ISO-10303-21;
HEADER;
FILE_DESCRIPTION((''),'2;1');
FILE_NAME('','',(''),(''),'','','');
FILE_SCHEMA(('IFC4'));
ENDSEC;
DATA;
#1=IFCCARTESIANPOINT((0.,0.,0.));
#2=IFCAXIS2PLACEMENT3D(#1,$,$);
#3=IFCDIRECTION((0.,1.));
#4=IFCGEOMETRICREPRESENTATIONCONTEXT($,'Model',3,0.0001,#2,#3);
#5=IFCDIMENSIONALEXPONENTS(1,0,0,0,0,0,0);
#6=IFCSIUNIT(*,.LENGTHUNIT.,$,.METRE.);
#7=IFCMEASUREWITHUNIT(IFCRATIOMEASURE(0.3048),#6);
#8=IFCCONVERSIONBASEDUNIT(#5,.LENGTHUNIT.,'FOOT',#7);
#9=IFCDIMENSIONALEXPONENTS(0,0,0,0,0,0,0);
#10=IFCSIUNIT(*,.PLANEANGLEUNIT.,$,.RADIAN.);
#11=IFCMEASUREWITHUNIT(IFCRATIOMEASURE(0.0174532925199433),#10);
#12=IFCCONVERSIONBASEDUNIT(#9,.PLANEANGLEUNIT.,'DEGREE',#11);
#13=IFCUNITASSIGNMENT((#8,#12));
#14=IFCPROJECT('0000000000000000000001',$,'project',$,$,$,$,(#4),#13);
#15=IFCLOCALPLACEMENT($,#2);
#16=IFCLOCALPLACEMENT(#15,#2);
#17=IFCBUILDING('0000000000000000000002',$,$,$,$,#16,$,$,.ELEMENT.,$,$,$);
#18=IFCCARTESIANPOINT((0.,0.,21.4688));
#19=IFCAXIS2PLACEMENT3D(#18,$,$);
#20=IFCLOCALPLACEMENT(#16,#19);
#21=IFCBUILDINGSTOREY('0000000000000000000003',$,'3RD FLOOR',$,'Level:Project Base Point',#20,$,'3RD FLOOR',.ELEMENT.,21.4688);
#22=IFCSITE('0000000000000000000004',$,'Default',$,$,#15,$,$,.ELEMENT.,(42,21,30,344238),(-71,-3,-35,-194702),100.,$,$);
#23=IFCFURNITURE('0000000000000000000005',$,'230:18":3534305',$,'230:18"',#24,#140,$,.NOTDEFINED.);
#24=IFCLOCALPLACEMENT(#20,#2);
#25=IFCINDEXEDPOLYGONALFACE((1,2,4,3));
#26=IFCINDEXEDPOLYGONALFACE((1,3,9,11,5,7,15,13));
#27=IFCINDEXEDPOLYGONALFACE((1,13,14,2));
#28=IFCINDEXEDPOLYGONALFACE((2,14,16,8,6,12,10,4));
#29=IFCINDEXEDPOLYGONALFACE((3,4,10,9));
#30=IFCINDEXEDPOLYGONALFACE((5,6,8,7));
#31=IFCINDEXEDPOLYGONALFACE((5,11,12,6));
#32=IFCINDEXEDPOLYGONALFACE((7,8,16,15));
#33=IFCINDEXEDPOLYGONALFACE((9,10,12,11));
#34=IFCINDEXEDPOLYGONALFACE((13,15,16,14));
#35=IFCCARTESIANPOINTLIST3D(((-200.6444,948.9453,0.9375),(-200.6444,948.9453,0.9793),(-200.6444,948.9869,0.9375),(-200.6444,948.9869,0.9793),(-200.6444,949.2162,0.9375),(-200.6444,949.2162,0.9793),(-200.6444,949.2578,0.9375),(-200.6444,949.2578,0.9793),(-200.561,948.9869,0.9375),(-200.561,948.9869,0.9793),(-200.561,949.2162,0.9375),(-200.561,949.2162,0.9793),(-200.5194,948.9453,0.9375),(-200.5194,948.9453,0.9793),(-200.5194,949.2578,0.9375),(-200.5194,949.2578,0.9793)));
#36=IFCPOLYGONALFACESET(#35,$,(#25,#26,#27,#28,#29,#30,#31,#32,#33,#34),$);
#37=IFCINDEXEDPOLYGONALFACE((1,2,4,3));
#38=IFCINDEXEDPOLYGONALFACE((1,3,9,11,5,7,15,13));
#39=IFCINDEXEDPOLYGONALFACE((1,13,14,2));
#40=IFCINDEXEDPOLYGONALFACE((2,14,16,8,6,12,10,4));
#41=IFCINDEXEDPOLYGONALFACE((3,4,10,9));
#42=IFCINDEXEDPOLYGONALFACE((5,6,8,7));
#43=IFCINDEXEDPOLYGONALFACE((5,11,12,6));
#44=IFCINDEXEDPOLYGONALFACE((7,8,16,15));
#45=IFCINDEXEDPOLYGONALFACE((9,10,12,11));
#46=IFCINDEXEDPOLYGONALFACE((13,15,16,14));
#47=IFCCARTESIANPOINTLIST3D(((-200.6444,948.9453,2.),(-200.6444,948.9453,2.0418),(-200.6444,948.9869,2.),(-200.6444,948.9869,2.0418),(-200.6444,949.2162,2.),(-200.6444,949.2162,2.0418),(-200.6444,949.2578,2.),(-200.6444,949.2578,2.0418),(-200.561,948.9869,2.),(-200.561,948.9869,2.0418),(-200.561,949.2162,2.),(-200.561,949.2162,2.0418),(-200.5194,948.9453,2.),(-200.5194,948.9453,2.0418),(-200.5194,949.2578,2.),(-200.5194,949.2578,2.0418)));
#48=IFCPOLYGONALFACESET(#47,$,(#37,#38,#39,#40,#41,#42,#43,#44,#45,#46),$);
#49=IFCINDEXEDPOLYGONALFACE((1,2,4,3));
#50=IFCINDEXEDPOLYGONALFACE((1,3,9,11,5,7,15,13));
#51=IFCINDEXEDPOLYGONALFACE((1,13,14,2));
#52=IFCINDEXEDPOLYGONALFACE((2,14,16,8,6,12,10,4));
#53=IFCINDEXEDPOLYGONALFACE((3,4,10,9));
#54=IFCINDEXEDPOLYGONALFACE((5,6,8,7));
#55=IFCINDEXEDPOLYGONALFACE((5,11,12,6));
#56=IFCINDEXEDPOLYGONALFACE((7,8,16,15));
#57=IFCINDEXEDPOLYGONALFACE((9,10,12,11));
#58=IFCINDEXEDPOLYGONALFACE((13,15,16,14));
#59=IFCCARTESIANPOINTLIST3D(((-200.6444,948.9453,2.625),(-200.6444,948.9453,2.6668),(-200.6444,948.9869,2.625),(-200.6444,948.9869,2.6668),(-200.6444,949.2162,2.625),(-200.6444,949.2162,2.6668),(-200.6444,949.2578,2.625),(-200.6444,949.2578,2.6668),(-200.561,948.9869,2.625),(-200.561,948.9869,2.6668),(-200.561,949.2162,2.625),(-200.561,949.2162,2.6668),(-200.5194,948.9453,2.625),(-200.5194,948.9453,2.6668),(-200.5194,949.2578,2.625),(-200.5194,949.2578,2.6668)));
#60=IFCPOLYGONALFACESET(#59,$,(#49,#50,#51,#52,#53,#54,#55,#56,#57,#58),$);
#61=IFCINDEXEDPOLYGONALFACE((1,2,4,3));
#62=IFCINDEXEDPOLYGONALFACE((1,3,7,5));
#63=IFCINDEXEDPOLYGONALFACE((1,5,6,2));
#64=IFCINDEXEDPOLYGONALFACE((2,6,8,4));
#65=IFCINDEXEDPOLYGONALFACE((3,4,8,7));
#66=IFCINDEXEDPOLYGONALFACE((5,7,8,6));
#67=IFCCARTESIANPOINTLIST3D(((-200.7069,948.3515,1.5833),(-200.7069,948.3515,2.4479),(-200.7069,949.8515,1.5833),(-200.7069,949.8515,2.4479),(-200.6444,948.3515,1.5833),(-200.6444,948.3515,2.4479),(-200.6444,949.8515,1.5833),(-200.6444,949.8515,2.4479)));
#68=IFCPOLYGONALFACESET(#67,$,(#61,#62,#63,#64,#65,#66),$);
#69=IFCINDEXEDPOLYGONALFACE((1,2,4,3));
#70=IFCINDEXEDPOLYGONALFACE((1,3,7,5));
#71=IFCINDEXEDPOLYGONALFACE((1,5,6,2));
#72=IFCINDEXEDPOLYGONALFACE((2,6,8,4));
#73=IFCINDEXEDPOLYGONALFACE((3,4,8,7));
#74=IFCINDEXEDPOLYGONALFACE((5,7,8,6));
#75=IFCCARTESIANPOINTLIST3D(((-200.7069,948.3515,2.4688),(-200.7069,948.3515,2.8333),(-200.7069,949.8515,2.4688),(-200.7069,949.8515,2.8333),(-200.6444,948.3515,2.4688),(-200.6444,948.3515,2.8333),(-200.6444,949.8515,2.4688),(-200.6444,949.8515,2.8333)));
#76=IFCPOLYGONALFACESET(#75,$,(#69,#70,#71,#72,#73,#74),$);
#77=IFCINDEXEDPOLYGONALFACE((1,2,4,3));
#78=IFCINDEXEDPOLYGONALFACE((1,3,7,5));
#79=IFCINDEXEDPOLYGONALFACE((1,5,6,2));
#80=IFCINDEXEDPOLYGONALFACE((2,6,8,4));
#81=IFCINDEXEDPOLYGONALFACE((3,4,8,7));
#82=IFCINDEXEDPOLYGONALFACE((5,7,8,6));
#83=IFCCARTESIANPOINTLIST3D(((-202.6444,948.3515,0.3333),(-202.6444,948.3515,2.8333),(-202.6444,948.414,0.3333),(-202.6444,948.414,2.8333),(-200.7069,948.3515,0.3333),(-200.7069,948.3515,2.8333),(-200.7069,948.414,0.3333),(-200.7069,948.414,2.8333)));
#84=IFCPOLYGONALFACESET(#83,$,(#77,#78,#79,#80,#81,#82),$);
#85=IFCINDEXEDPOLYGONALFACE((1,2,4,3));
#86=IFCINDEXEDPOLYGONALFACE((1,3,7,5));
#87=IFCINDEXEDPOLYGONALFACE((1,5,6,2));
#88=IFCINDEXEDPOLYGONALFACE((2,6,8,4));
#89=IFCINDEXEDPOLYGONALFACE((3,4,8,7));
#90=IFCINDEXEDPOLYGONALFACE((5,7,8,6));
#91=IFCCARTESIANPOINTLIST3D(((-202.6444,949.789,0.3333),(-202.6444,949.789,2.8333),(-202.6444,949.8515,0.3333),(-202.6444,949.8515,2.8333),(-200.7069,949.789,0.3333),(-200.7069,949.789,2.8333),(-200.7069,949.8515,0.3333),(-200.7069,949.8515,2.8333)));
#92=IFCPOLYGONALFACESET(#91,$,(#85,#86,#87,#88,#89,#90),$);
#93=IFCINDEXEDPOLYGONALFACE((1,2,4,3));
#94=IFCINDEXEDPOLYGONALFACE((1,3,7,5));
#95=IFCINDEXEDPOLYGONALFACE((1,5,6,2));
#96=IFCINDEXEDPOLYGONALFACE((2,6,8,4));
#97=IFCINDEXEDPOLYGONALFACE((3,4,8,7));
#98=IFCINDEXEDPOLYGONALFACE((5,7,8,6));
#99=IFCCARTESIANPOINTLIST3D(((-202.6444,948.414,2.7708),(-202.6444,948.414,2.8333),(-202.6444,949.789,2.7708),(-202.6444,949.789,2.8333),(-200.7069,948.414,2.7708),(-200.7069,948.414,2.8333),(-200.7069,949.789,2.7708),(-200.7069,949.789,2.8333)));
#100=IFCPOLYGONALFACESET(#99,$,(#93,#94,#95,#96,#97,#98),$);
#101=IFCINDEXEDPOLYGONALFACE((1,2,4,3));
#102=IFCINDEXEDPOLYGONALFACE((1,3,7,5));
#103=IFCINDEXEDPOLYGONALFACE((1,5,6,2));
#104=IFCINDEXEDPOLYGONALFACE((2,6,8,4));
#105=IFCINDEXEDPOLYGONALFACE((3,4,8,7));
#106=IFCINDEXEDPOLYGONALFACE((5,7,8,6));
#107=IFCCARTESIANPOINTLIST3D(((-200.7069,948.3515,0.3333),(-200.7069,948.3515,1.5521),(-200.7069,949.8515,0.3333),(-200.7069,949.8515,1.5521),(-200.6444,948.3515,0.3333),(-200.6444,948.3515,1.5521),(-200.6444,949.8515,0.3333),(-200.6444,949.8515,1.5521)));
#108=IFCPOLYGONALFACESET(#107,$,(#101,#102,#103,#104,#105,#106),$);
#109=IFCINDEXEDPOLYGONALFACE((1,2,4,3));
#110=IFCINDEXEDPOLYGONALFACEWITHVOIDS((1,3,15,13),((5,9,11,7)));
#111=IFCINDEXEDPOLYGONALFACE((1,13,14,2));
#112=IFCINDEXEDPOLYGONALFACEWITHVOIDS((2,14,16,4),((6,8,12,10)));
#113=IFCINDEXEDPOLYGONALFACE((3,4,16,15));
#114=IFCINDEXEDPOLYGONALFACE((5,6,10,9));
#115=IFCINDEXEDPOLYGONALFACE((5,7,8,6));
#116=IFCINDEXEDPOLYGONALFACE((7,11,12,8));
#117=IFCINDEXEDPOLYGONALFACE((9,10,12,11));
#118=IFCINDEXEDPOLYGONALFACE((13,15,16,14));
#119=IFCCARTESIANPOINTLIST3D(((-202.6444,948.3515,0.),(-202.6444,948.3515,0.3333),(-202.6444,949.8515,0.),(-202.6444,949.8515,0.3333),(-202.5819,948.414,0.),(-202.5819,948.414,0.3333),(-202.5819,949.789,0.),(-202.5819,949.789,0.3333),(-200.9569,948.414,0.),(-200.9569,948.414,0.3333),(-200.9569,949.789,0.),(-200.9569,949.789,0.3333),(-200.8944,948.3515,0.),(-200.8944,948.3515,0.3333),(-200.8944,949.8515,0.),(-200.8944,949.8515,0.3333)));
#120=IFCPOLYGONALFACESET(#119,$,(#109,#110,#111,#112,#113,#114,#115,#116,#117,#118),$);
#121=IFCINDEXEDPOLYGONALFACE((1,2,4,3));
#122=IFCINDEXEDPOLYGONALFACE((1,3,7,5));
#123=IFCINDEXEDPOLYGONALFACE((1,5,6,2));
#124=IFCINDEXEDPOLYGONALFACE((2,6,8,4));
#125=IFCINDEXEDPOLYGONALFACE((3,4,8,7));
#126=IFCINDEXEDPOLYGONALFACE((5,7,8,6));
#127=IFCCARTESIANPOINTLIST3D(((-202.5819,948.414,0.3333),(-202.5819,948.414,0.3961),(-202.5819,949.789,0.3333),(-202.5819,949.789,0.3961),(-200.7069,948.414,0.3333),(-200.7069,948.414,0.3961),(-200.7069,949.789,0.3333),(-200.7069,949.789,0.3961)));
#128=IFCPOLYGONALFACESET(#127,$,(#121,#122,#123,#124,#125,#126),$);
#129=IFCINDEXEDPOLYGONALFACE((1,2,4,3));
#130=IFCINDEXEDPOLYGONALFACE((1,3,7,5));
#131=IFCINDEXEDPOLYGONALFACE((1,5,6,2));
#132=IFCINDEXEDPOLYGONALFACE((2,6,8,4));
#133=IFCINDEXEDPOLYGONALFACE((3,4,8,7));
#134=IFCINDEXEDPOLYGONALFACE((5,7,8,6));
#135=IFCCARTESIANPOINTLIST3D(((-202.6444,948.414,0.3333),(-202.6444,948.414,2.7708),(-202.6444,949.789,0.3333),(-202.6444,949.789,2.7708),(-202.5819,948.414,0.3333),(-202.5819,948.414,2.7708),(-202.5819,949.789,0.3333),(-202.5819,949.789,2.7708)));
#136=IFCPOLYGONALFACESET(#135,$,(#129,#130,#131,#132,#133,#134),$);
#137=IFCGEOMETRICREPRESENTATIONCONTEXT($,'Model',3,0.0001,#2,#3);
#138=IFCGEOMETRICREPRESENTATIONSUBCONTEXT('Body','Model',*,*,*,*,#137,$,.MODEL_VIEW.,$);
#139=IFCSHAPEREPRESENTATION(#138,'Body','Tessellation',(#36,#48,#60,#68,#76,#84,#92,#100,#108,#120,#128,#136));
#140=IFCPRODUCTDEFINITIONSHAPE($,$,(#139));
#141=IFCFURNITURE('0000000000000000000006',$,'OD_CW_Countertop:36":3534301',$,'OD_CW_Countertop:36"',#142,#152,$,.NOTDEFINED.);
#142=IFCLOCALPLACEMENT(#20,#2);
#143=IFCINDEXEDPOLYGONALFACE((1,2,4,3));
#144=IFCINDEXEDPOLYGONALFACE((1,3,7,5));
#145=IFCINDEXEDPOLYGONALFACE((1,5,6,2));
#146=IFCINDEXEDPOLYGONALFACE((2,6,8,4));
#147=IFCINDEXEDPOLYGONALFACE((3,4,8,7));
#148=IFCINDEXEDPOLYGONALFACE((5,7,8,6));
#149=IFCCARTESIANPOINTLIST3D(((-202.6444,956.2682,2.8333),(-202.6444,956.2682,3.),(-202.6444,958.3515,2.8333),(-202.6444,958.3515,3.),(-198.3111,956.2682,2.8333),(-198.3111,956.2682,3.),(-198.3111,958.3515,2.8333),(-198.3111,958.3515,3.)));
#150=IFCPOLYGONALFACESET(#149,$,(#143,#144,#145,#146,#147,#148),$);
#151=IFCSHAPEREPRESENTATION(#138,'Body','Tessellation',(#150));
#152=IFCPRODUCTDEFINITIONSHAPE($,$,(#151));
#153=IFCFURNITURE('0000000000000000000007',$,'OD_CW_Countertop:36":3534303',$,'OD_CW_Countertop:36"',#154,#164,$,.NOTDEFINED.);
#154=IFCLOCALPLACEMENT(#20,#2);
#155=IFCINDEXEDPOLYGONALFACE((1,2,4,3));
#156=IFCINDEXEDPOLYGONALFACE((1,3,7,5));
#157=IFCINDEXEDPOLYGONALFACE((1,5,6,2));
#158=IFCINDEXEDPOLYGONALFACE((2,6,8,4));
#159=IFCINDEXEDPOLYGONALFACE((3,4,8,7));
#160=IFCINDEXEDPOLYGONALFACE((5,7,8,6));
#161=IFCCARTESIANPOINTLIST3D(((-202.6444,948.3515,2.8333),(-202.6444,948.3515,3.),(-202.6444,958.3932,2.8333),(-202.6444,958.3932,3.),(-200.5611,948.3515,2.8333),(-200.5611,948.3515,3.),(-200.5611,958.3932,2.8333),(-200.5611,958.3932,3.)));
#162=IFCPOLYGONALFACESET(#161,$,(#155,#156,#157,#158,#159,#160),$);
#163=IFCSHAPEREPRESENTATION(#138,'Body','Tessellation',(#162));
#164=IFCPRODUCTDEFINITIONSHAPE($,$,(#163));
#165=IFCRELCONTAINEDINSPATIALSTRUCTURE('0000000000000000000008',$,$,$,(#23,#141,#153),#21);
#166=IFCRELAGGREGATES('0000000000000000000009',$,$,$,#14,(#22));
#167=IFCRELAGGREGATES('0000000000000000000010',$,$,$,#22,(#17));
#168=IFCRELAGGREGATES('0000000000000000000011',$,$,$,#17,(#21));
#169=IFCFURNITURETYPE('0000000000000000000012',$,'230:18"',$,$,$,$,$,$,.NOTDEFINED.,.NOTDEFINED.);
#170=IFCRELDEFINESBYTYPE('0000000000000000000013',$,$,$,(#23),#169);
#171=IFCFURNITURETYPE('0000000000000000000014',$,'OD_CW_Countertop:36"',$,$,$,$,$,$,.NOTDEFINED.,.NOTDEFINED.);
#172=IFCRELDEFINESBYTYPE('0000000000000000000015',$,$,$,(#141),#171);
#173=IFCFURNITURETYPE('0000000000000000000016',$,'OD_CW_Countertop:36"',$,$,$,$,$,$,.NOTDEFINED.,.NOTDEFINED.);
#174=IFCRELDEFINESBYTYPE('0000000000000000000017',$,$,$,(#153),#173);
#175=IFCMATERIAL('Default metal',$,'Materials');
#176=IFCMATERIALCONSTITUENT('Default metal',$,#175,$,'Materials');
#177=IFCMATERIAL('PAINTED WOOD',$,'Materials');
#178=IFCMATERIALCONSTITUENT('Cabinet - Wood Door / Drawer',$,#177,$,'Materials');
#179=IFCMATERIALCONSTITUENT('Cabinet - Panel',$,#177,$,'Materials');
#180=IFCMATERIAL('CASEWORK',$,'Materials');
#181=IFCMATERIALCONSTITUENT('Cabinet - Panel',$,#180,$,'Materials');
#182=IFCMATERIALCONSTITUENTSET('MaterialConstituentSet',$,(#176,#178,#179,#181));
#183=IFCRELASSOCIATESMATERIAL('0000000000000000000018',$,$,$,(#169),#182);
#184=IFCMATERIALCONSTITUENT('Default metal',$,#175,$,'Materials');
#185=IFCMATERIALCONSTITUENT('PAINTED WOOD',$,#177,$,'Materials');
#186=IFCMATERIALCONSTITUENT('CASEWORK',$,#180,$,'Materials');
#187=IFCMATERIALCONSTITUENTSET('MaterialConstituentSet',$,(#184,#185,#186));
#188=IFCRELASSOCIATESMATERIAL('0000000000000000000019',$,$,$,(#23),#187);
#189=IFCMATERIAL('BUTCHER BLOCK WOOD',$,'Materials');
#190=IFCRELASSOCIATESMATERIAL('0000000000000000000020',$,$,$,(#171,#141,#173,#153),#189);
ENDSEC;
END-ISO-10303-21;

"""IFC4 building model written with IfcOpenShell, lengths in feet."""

from ifc_helpers import new_model, entity, si_unit, converted_unit, direction, frame, frame_2d, origin, origin_2d_with_axis, place, context, subcontext, project, spatial, polyline, rectangle, outline, extrude, source, transform, mapped, material, constituent, constituent_set, type_object, type_shapes, element, save


model = new_model("IFC4")

# Units and contexts
model_context_1 = context("Model", 3, precision=0.0001, world=origin(), true_north=direction((0.0, 1.0)))
model_context_2 = context("Model", 3, precision=0.0001, world=origin(), true_north=direction((0.0, 1.0)))
body_context = subcontext(model_context_2, "Body", "Model", "MODEL_VIEW")
ifc_project = project(units=[converted_unit("LENGTHUNIT", "FOOT", entity("IfcRatioMeasure", 0.3048), si_unit("LENGTHUNIT", "METRE"), dimensions=[1, 0, 0, 0, 0, 0, 0]), converted_unit("PLANEANGLEUNIT", "DEGREE", entity("IfcRatioMeasure", 0.0174532925199433), si_unit("PLANEANGLEUNIT", "RADIAN"), dimensions=[0, 0, 0, 0, 0, 0, 0])], contexts=[model_context_1])

# Site, building, storey
site_placement = place(None, origin())
site = spatial("IfcSite", under=ifc_project, at=site_placement, Name="Default", CompositionType="ELEMENT", RefLatitude=(42, 21, 30, 344238), RefLongitude=(-71, -3, -35, -194702), RefElevation=100.0)
building_placement = place(site_placement, origin())
building = spatial("IfcBuilding", under=site, at=building_placement, CompositionType="ELEMENT")
storey_placement = place(building_placement, frame((0.0, 0.0, 21.4688)))
storey = spatial("IfcBuildingStorey", under=building, at=storey_placement, Name="3RD FLOOR", ObjectType="Level:Project Base Point", LongName="3RD FLOOR", CompositionType="ELEMENT", Elevation=21.4688)

# Furniture
ifc_material_1 = material(Name="CASEWORK", Category="Materials")
ifc_material_2 = material(Name="Default metal", Category="Materials")
ifc_material_3 = material(Name="PAINTED WOOD", Category="Materials")
ifc_constituent_1 = constituent(ifc_material_2, Name="Default metal", Category="Materials")
ifc_constituent_2 = constituent(ifc_material_3, Name="PAINTED WOOD", Category="Materials")
ifc_constituent_3 = constituent(ifc_material_1, Name="CASEWORK", Category="Materials")
ifc_constituent_set_1 = constituent_set(constituents=[ifc_constituent_1, ifc_constituent_2, ifc_constituent_3], Name="MaterialConstituentSet")
ifc_constituent_4 = constituent(ifc_material_2, Name="Default metal", Category="Materials")
ifc_constituent_5 = constituent(ifc_material_3, Name="Cabinet - Wood Door / Drawer", Category="Materials")
ifc_constituent_6 = constituent(ifc_material_3, Name="Cabinet - Panel", Category="Materials")
ifc_constituent_7 = constituent(ifc_material_1, Name="Cabinet - Panel", Category="Materials")
ifc_constituent_set_2 = constituent_set(constituents=[ifc_constituent_4, ifc_constituent_5, ifc_constituent_6, ifc_constituent_7], Name="MaterialConstituentSet")
furniture_type_1 = type_object("IfcFurnitureType", Name="230:18\"", AssemblyPlace="NOTDEFINED", PredefinedType="NOTDEFINED", material=ifc_constituent_set_2)
shared_shape_1 = source(origin(), body_context, "Body", "SweptSolid", [
    extrude(outline(polyline([(-0.0521, -0.1562), (0.0729, -0.1562), (0.0729, 0.1562), (-0.0521, 0.1562), (-0.0521, 0.1146), (0.0313, 0.1146), (0.0313, -0.1146), (-0.0521, -0.1146), (-0.0521, -0.1562)])), frame((0.0615, -2.0521, 0.9375), z_axis=(0.0, 0.0, 1.0), x_axis=(0.0, -1.0, 0.0)), (0.0, 0.0, 1.0), 0.0418),
    extrude(outline(polyline([(-0.0521, -0.1562), (0.0729, -0.1562), (0.0729, 0.1562), (-0.0521, 0.1562), (-0.0521, 0.1146), (0.0313, 0.1146), (0.0313, -0.1146), (-0.0521, -0.1146), (-0.0521, -0.1562)])), frame((0.0615, -2.0521, 2.0), z_axis=(0.0, 0.0, 1.0), x_axis=(0.0, -1.0, 0.0)), (0.0, 0.0, 1.0), 0.0418),
    extrude(outline(polyline([(-0.0521, -0.1562), (0.0729, -0.1562), (0.0729, 0.1562), (-0.0521, 0.1562), (-0.0521, 0.1146), (0.0313, 0.1146), (0.0313, -0.1146), (-0.0521, -0.1146), (-0.0521, -0.1562)])), frame((0.0615, -2.0521, 2.625), z_axis=(0.0, 0.0, 1.0), x_axis=(0.0, -1.0, 0.0)), (0.0, 0.0, 1.0), 0.0418),
    extrude(rectangle(XDim=0.0625, YDim=1.5, at=frame_2d((0.0, 0.0), x_axis=(1.0, 0.0))), frame((0.0615, -1.9688, 1.5833), z_axis=(0.0, 0.0, 1.0), x_axis=(0.0, 1.0, 0.0)), (0.0, 0.0, 1.0), 0.8646),
    extrude(rectangle(XDim=0.0625, YDim=1.5, at=frame_2d((0.0, 0.0), x_axis=(1.0, 0.0))), frame((0.0615, -1.9688, 2.4688), z_axis=(0.0, 0.0, 1.0), x_axis=(0.0, 1.0, 0.0)), (0.0, 0.0, 1.0), 0.3646),
    extrude(rectangle(XDim=0.0625, YDim=1.9375, at=frame_2d((0.0, 0.0), x_axis=(1.0, 0.0))), frame((-0.6573, -0.9687, 0.3333)), (0.0, 0.0, 1.0), 2.5),
    extrude(rectangle(XDim=0.0625, YDim=1.9375, at=frame_2d((0.0, 0.0), x_axis=(1.0, 0.0))), frame((0.7802, -0.9687, 0.3333)), (0.0, 0.0, 1.0), 2.5),
    extrude(rectangle(XDim=1.375, YDim=1.9375, at=origin_2d_with_axis()), frame((0.0615, -0.9687, 2.7708), z_axis=(0.0, 0.0, 1.0), x_axis=(-1.0, 0.0, 0.0)), (0.0, 0.0, 1.0), 0.0625),
    extrude(rectangle(XDim=0.0625, YDim=1.5, at=frame_2d((0.0, 0.0), x_axis=(1.0, 0.0))), frame((0.0615, -1.9688, 0.3333), z_axis=(0.0, 0.0, 1.0), x_axis=(0.0, 1.0, 0.0)), (0.0, 0.0, 1.0), 1.2187),
    extrude(outline(polyline([(-0.75, -0.875), (0.75, -0.875), (0.75, 0.875), (-0.75, 0.875), (-0.75, -0.875)]), holes=[polyline([(-0.6875, -0.8125), (-0.6875, 0.8125), (0.6875, 0.8125), (0.6875, -0.8125), (-0.6875, -0.8125)])]), frame((0.0615, -0.875, 0.0)), (0.0, 0.0, 1.0), 0.3333),
    extrude(rectangle(XDim=1.375, YDim=1.875, at=frame_2d((0.0, 0.0), x_axis=(1.0, 0.0))), frame((0.0615, -1.0, 0.3333), z_axis=(0.0, 0.0, 1.0), x_axis=(-1.0, 0.0, 0.0)), (0.0, 0.0, 1.0), 0.0627),
    extrude(rectangle(XDim=0.0625, YDim=1.375, at=origin_2d_with_axis()), frame((0.0615, -0.0312, 0.3333), z_axis=(0.0, 0.0, 1.0), x_axis=(0.0, 1.0, 0.0)), (0.0, 0.0, 1.0), 2.4375),
])
type_shapes(furniture_type_1, [shared_shape_1])
furniture_1_placement = place(storey_placement, frame((-202.6444, 949.04, 0.0), z_axis=(0.0, 0.0, 1.0), x_axis=(0.0, 1.0, 0.0)))
element("IfcFurniture", 1, at=furniture_1_placement, inside=storey, type_object=furniture_type_1, material=ifc_constituent_set_1, Name="230:18\":3534305", ObjectType="230:18\"", PredefinedType="NOTDEFINED", context=body_context, shape_type="MappedRepresentation", body=[
    mapped(shared_shape_1, transform((0.0, 0.0, 0.0), scale=1.0)),
])
ifc_material_4 = material(Name="BUTCHER BLOCK WOOD", Category="Materials")
furniture_type_2 = type_object("IfcFurnitureType", Name="OD_CW_Countertop:36\"", AssemblyPlace="NOTDEFINED", PredefinedType="NOTDEFINED", material=ifc_material_4)
shared_shape_2 = source(origin(), body_context, "Body", "SweptSolid", [
    extrude(rectangle(XDim=4.3333, YDim=2.0833, at=origin_2d_with_axis()), frame((2.1667, 1.0417, 0.0)), (0.0, 0.0, 1.0), 0.1667),
])
type_shapes(furniture_type_2, [shared_shape_2])
furniture_2_placement = place(storey_placement, frame((-198.3111, 958.3515, 2.8333), z_axis=(0.0, 0.0, 1.0), x_axis=(-1.0, 0.0, 0.0)))
element("IfcFurniture", 2, at=furniture_2_placement, inside=storey, type_object=furniture_type_2, material=ifc_material_4, Name="OD_CW_Countertop:36\":3534301", ObjectType="OD_CW_Countertop:36\"", PredefinedType="NOTDEFINED", context=body_context, shape_type="MappedRepresentation", body=[
    mapped(shared_shape_2, transform((0.0, 0.0, 0.0), scale=1.0)),
])
furniture_type_3 = type_object("IfcFurnitureType", Name="OD_CW_Countertop:36\"", AssemblyPlace="NOTDEFINED", PredefinedType="NOTDEFINED", material=ifc_material_4)
shared_shape_3 = source(origin(), body_context, "Body", "SweptSolid", [
    extrude(rectangle(XDim=10.0417, YDim=2.0833, at=origin_2d_with_axis()), frame((5.0208, 1.0417, 0.0)), (0.0, 0.0, 1.0), 0.1667),
])
type_shapes(furniture_type_3, [shared_shape_3])
furniture_3_placement = place(storey_placement, frame((-202.6444, 958.3932, 2.8333), z_axis=(0.0, 0.0, 1.0), x_axis=(0.0, -1.0, 0.0)))
element("IfcFurniture", 3, at=furniture_3_placement, inside=storey, type_object=furniture_type_3, material=ifc_material_4, Name="OD_CW_Countertop:36\":3534303", ObjectType="OD_CW_Countertop:36\"", PredefinedType="NOTDEFINED", context=body_context, shape_type="MappedRepresentation", body=[
    mapped(shared_shape_3, transform((0.0, 0.0, 0.0), scale=1.0)),
])

save(model, "model.ifc")
